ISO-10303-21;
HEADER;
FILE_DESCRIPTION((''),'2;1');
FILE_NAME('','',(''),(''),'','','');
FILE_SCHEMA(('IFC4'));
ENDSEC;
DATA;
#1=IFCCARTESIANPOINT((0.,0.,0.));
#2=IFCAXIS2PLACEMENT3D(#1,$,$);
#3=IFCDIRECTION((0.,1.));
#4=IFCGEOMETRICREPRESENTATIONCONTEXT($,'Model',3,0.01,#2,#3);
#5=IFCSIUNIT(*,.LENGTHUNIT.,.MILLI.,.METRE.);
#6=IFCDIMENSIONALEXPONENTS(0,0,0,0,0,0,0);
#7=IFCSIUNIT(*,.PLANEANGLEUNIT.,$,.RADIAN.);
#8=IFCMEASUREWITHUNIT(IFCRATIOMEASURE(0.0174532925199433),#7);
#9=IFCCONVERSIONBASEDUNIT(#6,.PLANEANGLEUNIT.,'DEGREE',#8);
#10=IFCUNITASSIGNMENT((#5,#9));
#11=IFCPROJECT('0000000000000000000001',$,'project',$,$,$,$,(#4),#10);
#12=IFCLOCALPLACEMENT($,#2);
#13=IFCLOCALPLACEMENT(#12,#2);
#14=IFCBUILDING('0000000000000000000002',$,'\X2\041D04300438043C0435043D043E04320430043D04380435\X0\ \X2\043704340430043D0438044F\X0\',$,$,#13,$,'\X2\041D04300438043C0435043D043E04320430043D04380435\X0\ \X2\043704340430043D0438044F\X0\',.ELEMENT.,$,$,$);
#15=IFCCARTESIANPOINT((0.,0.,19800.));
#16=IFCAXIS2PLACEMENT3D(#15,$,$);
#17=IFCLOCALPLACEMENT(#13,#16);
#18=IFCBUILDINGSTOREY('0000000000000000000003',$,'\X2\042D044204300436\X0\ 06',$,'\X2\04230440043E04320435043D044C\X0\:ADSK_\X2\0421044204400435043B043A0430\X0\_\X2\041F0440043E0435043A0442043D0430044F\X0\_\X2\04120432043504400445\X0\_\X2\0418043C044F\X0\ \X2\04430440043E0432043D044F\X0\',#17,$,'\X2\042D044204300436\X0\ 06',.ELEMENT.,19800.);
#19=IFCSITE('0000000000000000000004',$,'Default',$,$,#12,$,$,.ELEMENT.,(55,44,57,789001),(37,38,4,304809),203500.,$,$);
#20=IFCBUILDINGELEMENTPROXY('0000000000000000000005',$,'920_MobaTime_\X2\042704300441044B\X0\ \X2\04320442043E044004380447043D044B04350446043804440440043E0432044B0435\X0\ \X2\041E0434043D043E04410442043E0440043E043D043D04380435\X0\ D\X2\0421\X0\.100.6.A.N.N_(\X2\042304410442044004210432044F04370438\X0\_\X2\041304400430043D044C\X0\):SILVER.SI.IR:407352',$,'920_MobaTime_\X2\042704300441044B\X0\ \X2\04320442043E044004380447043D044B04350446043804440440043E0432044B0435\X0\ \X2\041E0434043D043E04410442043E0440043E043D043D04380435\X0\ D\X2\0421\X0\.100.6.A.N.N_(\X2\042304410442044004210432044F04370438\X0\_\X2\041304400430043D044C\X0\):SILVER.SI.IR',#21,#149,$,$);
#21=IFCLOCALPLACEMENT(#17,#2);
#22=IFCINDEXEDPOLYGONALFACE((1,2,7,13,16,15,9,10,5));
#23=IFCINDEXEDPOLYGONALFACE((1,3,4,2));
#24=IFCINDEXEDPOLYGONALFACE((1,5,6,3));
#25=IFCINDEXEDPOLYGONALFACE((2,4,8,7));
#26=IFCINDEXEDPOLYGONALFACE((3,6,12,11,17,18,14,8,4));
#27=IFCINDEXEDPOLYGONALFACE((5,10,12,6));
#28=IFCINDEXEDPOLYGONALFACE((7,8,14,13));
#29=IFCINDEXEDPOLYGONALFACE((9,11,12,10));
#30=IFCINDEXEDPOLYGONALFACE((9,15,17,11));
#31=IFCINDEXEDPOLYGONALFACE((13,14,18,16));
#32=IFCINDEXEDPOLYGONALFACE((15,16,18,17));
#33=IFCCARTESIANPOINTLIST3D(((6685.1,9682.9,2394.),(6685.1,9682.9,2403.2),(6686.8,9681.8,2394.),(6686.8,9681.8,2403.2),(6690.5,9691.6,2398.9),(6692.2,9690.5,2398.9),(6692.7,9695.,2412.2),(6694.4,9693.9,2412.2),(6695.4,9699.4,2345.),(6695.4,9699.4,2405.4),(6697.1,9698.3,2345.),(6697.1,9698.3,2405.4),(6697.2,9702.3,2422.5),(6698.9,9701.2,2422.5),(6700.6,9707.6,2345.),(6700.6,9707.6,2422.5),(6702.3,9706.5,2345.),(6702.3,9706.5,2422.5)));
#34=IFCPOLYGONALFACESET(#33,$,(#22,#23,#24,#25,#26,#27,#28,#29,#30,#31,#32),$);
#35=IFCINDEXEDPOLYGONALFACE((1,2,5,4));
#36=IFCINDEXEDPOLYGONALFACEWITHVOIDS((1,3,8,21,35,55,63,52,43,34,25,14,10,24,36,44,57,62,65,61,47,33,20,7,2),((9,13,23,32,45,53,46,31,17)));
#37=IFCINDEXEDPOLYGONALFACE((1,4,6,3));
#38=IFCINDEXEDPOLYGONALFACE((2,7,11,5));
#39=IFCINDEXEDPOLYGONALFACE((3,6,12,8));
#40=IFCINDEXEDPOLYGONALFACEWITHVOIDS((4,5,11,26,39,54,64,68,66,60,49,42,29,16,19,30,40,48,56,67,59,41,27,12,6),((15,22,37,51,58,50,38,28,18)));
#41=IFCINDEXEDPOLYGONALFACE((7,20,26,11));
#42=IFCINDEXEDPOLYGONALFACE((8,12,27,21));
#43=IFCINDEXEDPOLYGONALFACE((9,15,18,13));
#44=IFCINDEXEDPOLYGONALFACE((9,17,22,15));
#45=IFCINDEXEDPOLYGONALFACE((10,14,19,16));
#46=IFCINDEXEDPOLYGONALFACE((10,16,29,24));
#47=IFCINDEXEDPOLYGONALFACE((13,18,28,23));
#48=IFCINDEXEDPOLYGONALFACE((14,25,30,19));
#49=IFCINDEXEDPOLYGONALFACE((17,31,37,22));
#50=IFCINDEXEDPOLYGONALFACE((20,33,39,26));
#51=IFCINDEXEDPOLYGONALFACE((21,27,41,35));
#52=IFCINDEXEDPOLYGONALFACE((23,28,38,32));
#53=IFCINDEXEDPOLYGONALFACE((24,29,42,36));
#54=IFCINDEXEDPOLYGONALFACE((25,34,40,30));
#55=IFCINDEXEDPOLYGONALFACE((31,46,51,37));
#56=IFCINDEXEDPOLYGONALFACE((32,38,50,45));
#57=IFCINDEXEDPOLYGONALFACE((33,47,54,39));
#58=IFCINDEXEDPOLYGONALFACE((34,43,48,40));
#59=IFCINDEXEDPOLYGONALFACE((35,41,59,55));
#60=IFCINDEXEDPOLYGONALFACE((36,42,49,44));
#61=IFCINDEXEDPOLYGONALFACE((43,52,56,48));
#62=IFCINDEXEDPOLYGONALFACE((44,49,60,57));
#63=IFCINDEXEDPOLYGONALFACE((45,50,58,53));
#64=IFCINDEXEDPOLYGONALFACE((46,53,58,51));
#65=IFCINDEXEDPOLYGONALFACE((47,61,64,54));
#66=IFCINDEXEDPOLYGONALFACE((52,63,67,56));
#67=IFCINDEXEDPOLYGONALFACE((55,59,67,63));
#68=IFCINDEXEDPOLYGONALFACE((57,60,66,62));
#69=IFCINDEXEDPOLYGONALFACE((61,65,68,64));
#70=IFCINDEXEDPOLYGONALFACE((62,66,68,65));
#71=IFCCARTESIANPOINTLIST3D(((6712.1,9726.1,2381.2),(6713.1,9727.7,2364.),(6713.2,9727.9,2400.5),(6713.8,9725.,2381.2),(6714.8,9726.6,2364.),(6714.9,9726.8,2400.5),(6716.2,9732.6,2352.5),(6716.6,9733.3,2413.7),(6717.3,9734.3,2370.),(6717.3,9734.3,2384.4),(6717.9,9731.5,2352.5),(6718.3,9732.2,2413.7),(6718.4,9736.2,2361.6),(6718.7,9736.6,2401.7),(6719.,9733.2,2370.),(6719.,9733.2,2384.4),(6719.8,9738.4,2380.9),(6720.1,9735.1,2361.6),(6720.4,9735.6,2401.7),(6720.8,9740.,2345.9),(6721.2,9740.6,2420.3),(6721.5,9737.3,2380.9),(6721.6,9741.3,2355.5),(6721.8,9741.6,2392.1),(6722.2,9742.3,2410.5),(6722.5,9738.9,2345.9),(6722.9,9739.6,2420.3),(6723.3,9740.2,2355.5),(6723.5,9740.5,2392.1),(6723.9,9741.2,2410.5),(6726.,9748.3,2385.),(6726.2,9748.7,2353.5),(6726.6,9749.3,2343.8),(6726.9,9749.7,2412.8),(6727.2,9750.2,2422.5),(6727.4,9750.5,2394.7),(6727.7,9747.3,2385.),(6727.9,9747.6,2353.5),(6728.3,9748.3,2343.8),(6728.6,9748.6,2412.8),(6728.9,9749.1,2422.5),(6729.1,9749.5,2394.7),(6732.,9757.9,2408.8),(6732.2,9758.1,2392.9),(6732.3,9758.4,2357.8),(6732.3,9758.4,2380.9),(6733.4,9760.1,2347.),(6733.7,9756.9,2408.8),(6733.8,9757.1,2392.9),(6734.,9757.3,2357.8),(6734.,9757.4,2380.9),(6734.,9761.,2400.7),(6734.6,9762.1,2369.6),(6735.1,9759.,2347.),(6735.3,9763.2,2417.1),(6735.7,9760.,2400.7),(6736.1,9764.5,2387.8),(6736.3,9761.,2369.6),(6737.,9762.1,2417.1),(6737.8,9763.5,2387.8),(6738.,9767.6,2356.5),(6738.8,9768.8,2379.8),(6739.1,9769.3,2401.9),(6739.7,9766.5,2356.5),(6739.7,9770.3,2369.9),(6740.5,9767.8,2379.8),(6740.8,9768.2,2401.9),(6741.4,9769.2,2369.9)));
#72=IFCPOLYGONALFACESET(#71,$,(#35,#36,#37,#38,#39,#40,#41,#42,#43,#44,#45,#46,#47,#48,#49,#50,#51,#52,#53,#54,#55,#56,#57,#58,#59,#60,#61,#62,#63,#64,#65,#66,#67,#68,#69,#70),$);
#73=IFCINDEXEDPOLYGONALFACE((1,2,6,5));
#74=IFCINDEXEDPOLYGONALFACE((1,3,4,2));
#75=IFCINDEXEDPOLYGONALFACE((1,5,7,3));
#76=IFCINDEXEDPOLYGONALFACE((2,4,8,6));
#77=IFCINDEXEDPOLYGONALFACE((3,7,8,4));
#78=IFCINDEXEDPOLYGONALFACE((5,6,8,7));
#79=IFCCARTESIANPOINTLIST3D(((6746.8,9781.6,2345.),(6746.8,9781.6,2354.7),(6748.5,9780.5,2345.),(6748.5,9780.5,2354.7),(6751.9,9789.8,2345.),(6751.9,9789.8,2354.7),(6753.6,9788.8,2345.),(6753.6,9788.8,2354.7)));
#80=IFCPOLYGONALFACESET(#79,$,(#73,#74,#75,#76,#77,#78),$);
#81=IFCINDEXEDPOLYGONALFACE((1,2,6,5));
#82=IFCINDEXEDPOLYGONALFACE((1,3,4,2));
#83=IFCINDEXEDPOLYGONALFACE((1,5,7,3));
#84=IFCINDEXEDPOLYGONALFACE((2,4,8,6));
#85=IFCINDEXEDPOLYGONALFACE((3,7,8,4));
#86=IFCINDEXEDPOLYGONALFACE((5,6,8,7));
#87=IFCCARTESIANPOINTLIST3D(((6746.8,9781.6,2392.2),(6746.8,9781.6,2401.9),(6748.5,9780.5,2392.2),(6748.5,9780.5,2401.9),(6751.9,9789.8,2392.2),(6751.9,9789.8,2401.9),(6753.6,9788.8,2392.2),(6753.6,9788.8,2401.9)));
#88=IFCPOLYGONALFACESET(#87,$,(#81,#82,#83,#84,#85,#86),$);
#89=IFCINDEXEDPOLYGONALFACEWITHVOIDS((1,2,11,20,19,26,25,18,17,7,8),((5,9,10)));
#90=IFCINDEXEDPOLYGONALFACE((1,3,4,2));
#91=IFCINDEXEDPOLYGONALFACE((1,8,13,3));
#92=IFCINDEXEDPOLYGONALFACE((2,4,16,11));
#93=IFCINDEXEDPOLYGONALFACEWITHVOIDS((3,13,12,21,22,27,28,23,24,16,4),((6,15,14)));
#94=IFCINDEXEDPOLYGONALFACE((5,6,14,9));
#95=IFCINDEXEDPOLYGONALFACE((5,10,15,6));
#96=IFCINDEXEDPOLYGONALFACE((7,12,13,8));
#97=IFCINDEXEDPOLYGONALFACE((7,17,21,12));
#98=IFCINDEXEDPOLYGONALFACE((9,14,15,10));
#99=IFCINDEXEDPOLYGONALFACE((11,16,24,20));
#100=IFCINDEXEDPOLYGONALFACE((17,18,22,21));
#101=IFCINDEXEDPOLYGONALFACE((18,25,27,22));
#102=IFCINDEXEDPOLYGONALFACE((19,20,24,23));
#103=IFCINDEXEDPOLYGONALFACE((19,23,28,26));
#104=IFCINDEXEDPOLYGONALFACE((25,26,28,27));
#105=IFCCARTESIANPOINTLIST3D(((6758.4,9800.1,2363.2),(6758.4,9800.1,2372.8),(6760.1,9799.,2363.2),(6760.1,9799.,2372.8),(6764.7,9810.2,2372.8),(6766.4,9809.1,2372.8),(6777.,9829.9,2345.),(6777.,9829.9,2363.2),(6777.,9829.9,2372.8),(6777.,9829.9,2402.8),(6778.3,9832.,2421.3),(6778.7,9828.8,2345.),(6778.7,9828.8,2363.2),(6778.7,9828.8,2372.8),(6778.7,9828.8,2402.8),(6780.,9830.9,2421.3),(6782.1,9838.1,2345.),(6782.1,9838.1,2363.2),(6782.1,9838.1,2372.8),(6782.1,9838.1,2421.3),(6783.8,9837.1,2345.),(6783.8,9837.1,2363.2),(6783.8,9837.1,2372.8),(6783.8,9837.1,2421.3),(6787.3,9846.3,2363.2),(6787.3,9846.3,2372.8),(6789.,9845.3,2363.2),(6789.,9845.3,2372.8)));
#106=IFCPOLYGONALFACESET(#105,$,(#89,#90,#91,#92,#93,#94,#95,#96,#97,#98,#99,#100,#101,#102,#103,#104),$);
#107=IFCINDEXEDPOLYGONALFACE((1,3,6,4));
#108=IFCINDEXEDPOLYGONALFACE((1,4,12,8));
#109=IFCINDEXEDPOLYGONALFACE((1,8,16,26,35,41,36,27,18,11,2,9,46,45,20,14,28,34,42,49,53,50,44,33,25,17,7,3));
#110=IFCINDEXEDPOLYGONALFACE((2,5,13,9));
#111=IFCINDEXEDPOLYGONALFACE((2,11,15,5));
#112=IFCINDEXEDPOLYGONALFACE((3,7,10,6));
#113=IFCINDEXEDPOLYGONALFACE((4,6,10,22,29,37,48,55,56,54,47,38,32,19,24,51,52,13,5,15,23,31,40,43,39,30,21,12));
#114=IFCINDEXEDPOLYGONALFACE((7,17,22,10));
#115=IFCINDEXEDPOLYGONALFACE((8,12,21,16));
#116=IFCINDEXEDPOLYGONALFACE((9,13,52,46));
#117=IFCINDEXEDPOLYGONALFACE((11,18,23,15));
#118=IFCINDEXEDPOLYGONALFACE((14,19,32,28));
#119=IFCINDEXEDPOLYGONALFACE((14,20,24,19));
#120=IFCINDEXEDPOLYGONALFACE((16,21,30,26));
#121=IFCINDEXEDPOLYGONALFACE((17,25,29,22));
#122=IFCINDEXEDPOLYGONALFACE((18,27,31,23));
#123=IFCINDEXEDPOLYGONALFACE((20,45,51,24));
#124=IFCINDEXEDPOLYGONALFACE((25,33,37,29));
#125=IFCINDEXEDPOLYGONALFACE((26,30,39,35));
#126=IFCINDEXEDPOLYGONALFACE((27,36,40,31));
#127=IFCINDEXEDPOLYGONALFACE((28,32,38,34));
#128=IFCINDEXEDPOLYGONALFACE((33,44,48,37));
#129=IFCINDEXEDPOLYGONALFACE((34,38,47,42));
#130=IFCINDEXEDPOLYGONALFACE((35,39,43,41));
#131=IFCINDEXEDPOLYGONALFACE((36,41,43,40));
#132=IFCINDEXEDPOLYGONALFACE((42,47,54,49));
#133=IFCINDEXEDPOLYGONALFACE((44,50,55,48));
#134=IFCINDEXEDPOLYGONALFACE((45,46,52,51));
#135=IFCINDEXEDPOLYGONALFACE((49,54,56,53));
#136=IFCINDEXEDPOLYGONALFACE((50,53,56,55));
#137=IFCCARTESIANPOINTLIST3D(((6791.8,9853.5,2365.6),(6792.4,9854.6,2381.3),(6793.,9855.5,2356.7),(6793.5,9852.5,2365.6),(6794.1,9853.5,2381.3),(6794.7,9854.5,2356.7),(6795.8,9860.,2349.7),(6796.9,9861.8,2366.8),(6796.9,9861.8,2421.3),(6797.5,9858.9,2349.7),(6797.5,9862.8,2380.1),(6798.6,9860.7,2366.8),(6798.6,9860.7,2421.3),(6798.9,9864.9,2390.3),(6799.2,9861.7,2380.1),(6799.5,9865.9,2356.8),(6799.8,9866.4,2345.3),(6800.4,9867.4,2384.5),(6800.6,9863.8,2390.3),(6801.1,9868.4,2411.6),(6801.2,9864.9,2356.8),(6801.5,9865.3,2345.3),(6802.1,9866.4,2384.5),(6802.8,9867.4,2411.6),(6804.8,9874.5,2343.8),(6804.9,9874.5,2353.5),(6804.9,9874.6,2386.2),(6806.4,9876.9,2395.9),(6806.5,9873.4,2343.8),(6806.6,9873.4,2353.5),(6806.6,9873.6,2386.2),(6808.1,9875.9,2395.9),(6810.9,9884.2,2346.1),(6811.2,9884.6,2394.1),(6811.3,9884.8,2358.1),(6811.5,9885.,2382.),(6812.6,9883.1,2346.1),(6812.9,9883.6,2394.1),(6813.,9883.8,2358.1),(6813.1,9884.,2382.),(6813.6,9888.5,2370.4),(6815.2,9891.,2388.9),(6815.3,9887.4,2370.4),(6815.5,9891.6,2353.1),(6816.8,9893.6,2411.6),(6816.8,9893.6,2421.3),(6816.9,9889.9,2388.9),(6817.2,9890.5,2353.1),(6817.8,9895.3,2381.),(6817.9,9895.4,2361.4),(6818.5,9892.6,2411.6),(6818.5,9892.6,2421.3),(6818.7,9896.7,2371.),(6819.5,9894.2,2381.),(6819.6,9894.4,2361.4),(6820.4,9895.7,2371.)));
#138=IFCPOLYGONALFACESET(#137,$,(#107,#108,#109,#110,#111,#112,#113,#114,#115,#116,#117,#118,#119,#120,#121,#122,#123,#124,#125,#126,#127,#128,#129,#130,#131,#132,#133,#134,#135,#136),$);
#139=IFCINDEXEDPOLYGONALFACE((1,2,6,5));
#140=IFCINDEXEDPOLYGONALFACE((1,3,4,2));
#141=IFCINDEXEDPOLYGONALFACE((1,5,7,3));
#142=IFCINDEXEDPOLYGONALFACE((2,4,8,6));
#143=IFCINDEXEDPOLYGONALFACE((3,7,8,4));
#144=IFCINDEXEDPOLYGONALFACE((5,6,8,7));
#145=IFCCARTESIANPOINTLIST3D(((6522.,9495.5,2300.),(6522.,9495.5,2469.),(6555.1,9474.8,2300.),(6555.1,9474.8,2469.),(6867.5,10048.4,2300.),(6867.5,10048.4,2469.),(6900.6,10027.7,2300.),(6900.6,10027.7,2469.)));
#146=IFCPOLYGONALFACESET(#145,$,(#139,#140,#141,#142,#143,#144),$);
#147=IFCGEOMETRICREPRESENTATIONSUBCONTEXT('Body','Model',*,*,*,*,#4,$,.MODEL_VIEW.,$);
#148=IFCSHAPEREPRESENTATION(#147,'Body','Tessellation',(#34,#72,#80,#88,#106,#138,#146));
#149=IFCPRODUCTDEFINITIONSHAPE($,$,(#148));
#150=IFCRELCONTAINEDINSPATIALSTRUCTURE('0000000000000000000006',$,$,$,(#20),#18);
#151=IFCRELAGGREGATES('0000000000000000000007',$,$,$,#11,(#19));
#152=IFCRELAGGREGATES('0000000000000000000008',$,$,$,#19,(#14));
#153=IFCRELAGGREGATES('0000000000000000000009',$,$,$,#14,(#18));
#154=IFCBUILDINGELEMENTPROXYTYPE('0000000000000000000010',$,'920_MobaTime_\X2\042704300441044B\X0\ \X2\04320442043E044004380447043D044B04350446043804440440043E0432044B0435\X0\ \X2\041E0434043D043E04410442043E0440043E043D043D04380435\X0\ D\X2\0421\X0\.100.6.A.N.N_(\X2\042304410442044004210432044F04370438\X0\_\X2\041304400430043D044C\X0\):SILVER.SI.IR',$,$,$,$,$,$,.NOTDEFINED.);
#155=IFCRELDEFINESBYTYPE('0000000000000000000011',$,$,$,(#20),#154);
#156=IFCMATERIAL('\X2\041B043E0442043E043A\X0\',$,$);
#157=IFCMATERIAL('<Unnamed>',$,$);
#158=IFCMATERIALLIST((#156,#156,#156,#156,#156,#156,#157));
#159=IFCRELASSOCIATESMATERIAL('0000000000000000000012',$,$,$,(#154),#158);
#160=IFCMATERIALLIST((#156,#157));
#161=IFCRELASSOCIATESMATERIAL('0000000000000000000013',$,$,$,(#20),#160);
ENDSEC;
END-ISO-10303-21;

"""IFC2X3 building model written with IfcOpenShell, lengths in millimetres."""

from ifc_helpers import new_model, entity, si_unit, converted_unit, direction, frame, origin, origin_2d_with_axis, place, context, subcontext, project, spatial, polyline, rectangle, outline, extrude, source, transform, mapped, material, material_list, type_object, type_shapes, element, save


model = new_model("IFC2X3")

# Units and contexts
model_context = context("Model", 3, precision=0.01, world=origin(), true_north=direction((0.0, 1.0)))
body_context = subcontext(model_context, "Body", "Model", "MODEL_VIEW")
ifc_project = project(units=[si_unit("LENGTHUNIT", "METRE", prefix="MILLI"), converted_unit("PLANEANGLEUNIT", "DEGREE", entity("IfcRatioMeasure", 0.0174532925199433), si_unit("PLANEANGLEUNIT", "RADIAN"), dimensions=[0, 0, 0, 0, 0, 0, 0])], contexts=[model_context])

# Site, building, storey
site_placement = place(None, frame((0.0, 0.0, 0.0)))
site = spatial("IfcSite", under=ifc_project, at=site_placement, Name="Default", CompositionType="ELEMENT", RefLatitude=(55, 44, 57, 789001), RefLongitude=(37, 38, 4, 304809), RefElevation=203500.0)
building_placement = place(site_placement, origin())
building = spatial("IfcBuilding", under=site, at=building_placement, Name="Наименование здания", LongName="Наименование здания", CompositionType="ELEMENT")
storey_placement = place(building_placement, frame((0.0, 0.0, 19800.0)))
storey = spatial("IfcBuildingStorey", under=building, at=storey_placement, Name="Этаж 06", ObjectType="Уровень:ADSK_Стрелка_Проектная_Вверх_Имя уровня", LongName="Этаж 06", CompositionType="ELEMENT", Elevation=19800.0)

# Building element proxy
ifc_material_1 = material(Name="Лоток")
ifc_material_2 = material(Name="<Unnamed>")
ifc_material_list_1 = material_list([ifc_material_1, ifc_material_1, ifc_material_1, ifc_material_1, ifc_material_1, ifc_material_1, ifc_material_2])
building_element_proxy_type_1 = type_object("IfcBuildingElementProxyType", Name="920_MobaTime_Часы вторичныецифровые Односторонние DС.100.6.A.N.N_(УстрСвязи_Грань):SILVER.SI.IR", PredefinedType="NOTDEFINED", material=ifc_material_list_1)
shared_shape_1 = source(origin(), body_context, "Body", "SweptSolid", [
    extrude(outline(polyline([(-49.3, -13.1), (28.2, -13.1), (28.2, -6.8), (17.9, 1.8), (8.9, 16.0), (-0.3, 16.0), (4.6, 5.8), (11.1, -3.4), (-49.3, -3.4), (-49.3, -13.1)])), frame((-64.6, 9.8, 39.0), z_axis=(0.0, 0.0, 1.0), x_axis=(0.0, 1.0, 0.0)), (0.0, 0.0, 1.0), 2.0),
    extrude(outline(polyline([(2.2, -27.6), (19.0, -27.6), (30.5, -16.1), (33.3, -4.9), (31.0, 5.8), (21.8, 17.2), (5.2, 27.3), (-11.1, 33.0), (-24.0, 32.7), (-33.6, 27.6), (-40.3, 18.6), (-42.8, 5.7), (-38.0, -6.3), (-27.2, -15.0), (-17.5, -17.7), (-8.2, -16.4), (-0.3, -11.9), (5.1, -4.5), (7.3, 6.2), (4.0, 17.2), (18.5, 7.3), (23.6, -2.4), (22.0, -11.4), (14.2, -18.4), (5.3, -18.3), (2.2, -27.6)]), holes=[polyline([(-9.0, 23.3), (-1.3, 14.4), (-2.6, 2.0), (-11.4, -7.0), (-23.4, -6.1), (-32.2, 2.9), (-31.2, 15.1), (-25.6, 22.1), (-17.5, 24.9), (-9.0, 23.3)])]), frame((-2.7, 3.6, 39.0), z_axis=(0.0, 0.0, 1.0), x_axis=(-0.427649, 0.903945, 0.0)), (0.0, 0.0, 1.0), 2.0),
    extrude(rectangle(XDim=9.7, YDim=9.7, at=origin_2d_with_axis()), frame((40.6, -34.7, 39.0)), (0.0, 0.0, 1.0), 2.0),
    extrude(rectangle(XDim=9.7, YDim=9.7, at=origin_2d_with_axis()), frame((40.6, 12.6, 39.0)), (0.0, 0.0, 1.0), 2.0),
    extrude(outline(polyline([(-0.9, -28.1), (8.8, -28.1), (8.8, -9.9), (18.5, -9.9), (18.5, -0.2), (8.8, -0.2), (8.8, 48.3), (1.5, 48.3), (-36.0, -0.2), (-36.0, -9.9), (-0.9, -9.9), (-0.9, -28.1)]), holes=[polyline([(-0.9, -0.2), (-24.1, -0.2), (-0.9, 29.7), (-0.9, -0.2)])]), frame((93.6, -11.4, 39.0)), (0.0, 0.0, 1.0), 2.0),
    extrude(outline(polyline([(3.3, -28.3), (12.5, -28.3), (20.5, -25.0), (26.8, -18.8), (30.7, -10.0), (31.4, 1.6), (26.9, 11.8), (20.1, 18.4), (11.1, 22.3), (1.0, 23.3), (-7.9, 20.4), (-14.9, 14.5), (-18.9, 6.2), (-17.1, -9.0), (-36.7, 0.5), (-29.1, 29.3), (-38.5, 31.7), (-48.1, -4.6), (-11.6, -23.0), (-8.0, -14.0), (-10.8, -7.6), (-10.2, 1.1), (-3.0, 11.8), (9.2, 12.8), (20.0, 5.4), (21.3, -7.5), (15.5, -16.4), (4.6, -18.6), (3.3, -28.3)])), frame((147.1, -8.5, 39.0), z_axis=(0.0, 0.0, 1.0), x_axis=(0.256974, -0.966418, 0.0)), (0.0, 0.0, 1.0), 2.0),
    extrude(rectangle(XDim=652.0, YDim=169.0, at=origin_2d_with_axis()), frame((0.0, 0.0, 0.0), z_axis=(0.0, 0.0, 1.0), x_axis=(-1.0, 0.0, 0.0)), (0.0, 0.0, 1.0), 39.0),
])
type_shapes(building_element_proxy_type_1, [shared_shape_1])
ifc_material_list_2 = material_list([ifc_material_1, ifc_material_2])
proxy_1_placement = place(storey_placement, frame((6694.8, 9771.9, 2384.5), z_axis=(0.848048, -0.529919, 0.0), x_axis=(0.529919, 0.848048, 0.0)))
element("IfcBuildingElementProxy", 1, at=proxy_1_placement, inside=storey, type_object=building_element_proxy_type_1, material=ifc_material_list_2, Name="920_MobaTime_Часы вторичныецифровые Односторонние DС.100.6.A.N.N_(УстрСвязи_Грань):SILVER.SI.IR:407352", ObjectType="920_MobaTime_Часы вторичныецифровые Односторонние DС.100.6.A.N.N_(УстрСвязи_Грань):SILVER.SI.IR", context=body_context, shape_type="MappedRepresentation", body=[
    mapped(shared_shape_1, transform((0.0, 0.0, 0.0), scale=1.0)),
])

save(model, "model.ifc")
